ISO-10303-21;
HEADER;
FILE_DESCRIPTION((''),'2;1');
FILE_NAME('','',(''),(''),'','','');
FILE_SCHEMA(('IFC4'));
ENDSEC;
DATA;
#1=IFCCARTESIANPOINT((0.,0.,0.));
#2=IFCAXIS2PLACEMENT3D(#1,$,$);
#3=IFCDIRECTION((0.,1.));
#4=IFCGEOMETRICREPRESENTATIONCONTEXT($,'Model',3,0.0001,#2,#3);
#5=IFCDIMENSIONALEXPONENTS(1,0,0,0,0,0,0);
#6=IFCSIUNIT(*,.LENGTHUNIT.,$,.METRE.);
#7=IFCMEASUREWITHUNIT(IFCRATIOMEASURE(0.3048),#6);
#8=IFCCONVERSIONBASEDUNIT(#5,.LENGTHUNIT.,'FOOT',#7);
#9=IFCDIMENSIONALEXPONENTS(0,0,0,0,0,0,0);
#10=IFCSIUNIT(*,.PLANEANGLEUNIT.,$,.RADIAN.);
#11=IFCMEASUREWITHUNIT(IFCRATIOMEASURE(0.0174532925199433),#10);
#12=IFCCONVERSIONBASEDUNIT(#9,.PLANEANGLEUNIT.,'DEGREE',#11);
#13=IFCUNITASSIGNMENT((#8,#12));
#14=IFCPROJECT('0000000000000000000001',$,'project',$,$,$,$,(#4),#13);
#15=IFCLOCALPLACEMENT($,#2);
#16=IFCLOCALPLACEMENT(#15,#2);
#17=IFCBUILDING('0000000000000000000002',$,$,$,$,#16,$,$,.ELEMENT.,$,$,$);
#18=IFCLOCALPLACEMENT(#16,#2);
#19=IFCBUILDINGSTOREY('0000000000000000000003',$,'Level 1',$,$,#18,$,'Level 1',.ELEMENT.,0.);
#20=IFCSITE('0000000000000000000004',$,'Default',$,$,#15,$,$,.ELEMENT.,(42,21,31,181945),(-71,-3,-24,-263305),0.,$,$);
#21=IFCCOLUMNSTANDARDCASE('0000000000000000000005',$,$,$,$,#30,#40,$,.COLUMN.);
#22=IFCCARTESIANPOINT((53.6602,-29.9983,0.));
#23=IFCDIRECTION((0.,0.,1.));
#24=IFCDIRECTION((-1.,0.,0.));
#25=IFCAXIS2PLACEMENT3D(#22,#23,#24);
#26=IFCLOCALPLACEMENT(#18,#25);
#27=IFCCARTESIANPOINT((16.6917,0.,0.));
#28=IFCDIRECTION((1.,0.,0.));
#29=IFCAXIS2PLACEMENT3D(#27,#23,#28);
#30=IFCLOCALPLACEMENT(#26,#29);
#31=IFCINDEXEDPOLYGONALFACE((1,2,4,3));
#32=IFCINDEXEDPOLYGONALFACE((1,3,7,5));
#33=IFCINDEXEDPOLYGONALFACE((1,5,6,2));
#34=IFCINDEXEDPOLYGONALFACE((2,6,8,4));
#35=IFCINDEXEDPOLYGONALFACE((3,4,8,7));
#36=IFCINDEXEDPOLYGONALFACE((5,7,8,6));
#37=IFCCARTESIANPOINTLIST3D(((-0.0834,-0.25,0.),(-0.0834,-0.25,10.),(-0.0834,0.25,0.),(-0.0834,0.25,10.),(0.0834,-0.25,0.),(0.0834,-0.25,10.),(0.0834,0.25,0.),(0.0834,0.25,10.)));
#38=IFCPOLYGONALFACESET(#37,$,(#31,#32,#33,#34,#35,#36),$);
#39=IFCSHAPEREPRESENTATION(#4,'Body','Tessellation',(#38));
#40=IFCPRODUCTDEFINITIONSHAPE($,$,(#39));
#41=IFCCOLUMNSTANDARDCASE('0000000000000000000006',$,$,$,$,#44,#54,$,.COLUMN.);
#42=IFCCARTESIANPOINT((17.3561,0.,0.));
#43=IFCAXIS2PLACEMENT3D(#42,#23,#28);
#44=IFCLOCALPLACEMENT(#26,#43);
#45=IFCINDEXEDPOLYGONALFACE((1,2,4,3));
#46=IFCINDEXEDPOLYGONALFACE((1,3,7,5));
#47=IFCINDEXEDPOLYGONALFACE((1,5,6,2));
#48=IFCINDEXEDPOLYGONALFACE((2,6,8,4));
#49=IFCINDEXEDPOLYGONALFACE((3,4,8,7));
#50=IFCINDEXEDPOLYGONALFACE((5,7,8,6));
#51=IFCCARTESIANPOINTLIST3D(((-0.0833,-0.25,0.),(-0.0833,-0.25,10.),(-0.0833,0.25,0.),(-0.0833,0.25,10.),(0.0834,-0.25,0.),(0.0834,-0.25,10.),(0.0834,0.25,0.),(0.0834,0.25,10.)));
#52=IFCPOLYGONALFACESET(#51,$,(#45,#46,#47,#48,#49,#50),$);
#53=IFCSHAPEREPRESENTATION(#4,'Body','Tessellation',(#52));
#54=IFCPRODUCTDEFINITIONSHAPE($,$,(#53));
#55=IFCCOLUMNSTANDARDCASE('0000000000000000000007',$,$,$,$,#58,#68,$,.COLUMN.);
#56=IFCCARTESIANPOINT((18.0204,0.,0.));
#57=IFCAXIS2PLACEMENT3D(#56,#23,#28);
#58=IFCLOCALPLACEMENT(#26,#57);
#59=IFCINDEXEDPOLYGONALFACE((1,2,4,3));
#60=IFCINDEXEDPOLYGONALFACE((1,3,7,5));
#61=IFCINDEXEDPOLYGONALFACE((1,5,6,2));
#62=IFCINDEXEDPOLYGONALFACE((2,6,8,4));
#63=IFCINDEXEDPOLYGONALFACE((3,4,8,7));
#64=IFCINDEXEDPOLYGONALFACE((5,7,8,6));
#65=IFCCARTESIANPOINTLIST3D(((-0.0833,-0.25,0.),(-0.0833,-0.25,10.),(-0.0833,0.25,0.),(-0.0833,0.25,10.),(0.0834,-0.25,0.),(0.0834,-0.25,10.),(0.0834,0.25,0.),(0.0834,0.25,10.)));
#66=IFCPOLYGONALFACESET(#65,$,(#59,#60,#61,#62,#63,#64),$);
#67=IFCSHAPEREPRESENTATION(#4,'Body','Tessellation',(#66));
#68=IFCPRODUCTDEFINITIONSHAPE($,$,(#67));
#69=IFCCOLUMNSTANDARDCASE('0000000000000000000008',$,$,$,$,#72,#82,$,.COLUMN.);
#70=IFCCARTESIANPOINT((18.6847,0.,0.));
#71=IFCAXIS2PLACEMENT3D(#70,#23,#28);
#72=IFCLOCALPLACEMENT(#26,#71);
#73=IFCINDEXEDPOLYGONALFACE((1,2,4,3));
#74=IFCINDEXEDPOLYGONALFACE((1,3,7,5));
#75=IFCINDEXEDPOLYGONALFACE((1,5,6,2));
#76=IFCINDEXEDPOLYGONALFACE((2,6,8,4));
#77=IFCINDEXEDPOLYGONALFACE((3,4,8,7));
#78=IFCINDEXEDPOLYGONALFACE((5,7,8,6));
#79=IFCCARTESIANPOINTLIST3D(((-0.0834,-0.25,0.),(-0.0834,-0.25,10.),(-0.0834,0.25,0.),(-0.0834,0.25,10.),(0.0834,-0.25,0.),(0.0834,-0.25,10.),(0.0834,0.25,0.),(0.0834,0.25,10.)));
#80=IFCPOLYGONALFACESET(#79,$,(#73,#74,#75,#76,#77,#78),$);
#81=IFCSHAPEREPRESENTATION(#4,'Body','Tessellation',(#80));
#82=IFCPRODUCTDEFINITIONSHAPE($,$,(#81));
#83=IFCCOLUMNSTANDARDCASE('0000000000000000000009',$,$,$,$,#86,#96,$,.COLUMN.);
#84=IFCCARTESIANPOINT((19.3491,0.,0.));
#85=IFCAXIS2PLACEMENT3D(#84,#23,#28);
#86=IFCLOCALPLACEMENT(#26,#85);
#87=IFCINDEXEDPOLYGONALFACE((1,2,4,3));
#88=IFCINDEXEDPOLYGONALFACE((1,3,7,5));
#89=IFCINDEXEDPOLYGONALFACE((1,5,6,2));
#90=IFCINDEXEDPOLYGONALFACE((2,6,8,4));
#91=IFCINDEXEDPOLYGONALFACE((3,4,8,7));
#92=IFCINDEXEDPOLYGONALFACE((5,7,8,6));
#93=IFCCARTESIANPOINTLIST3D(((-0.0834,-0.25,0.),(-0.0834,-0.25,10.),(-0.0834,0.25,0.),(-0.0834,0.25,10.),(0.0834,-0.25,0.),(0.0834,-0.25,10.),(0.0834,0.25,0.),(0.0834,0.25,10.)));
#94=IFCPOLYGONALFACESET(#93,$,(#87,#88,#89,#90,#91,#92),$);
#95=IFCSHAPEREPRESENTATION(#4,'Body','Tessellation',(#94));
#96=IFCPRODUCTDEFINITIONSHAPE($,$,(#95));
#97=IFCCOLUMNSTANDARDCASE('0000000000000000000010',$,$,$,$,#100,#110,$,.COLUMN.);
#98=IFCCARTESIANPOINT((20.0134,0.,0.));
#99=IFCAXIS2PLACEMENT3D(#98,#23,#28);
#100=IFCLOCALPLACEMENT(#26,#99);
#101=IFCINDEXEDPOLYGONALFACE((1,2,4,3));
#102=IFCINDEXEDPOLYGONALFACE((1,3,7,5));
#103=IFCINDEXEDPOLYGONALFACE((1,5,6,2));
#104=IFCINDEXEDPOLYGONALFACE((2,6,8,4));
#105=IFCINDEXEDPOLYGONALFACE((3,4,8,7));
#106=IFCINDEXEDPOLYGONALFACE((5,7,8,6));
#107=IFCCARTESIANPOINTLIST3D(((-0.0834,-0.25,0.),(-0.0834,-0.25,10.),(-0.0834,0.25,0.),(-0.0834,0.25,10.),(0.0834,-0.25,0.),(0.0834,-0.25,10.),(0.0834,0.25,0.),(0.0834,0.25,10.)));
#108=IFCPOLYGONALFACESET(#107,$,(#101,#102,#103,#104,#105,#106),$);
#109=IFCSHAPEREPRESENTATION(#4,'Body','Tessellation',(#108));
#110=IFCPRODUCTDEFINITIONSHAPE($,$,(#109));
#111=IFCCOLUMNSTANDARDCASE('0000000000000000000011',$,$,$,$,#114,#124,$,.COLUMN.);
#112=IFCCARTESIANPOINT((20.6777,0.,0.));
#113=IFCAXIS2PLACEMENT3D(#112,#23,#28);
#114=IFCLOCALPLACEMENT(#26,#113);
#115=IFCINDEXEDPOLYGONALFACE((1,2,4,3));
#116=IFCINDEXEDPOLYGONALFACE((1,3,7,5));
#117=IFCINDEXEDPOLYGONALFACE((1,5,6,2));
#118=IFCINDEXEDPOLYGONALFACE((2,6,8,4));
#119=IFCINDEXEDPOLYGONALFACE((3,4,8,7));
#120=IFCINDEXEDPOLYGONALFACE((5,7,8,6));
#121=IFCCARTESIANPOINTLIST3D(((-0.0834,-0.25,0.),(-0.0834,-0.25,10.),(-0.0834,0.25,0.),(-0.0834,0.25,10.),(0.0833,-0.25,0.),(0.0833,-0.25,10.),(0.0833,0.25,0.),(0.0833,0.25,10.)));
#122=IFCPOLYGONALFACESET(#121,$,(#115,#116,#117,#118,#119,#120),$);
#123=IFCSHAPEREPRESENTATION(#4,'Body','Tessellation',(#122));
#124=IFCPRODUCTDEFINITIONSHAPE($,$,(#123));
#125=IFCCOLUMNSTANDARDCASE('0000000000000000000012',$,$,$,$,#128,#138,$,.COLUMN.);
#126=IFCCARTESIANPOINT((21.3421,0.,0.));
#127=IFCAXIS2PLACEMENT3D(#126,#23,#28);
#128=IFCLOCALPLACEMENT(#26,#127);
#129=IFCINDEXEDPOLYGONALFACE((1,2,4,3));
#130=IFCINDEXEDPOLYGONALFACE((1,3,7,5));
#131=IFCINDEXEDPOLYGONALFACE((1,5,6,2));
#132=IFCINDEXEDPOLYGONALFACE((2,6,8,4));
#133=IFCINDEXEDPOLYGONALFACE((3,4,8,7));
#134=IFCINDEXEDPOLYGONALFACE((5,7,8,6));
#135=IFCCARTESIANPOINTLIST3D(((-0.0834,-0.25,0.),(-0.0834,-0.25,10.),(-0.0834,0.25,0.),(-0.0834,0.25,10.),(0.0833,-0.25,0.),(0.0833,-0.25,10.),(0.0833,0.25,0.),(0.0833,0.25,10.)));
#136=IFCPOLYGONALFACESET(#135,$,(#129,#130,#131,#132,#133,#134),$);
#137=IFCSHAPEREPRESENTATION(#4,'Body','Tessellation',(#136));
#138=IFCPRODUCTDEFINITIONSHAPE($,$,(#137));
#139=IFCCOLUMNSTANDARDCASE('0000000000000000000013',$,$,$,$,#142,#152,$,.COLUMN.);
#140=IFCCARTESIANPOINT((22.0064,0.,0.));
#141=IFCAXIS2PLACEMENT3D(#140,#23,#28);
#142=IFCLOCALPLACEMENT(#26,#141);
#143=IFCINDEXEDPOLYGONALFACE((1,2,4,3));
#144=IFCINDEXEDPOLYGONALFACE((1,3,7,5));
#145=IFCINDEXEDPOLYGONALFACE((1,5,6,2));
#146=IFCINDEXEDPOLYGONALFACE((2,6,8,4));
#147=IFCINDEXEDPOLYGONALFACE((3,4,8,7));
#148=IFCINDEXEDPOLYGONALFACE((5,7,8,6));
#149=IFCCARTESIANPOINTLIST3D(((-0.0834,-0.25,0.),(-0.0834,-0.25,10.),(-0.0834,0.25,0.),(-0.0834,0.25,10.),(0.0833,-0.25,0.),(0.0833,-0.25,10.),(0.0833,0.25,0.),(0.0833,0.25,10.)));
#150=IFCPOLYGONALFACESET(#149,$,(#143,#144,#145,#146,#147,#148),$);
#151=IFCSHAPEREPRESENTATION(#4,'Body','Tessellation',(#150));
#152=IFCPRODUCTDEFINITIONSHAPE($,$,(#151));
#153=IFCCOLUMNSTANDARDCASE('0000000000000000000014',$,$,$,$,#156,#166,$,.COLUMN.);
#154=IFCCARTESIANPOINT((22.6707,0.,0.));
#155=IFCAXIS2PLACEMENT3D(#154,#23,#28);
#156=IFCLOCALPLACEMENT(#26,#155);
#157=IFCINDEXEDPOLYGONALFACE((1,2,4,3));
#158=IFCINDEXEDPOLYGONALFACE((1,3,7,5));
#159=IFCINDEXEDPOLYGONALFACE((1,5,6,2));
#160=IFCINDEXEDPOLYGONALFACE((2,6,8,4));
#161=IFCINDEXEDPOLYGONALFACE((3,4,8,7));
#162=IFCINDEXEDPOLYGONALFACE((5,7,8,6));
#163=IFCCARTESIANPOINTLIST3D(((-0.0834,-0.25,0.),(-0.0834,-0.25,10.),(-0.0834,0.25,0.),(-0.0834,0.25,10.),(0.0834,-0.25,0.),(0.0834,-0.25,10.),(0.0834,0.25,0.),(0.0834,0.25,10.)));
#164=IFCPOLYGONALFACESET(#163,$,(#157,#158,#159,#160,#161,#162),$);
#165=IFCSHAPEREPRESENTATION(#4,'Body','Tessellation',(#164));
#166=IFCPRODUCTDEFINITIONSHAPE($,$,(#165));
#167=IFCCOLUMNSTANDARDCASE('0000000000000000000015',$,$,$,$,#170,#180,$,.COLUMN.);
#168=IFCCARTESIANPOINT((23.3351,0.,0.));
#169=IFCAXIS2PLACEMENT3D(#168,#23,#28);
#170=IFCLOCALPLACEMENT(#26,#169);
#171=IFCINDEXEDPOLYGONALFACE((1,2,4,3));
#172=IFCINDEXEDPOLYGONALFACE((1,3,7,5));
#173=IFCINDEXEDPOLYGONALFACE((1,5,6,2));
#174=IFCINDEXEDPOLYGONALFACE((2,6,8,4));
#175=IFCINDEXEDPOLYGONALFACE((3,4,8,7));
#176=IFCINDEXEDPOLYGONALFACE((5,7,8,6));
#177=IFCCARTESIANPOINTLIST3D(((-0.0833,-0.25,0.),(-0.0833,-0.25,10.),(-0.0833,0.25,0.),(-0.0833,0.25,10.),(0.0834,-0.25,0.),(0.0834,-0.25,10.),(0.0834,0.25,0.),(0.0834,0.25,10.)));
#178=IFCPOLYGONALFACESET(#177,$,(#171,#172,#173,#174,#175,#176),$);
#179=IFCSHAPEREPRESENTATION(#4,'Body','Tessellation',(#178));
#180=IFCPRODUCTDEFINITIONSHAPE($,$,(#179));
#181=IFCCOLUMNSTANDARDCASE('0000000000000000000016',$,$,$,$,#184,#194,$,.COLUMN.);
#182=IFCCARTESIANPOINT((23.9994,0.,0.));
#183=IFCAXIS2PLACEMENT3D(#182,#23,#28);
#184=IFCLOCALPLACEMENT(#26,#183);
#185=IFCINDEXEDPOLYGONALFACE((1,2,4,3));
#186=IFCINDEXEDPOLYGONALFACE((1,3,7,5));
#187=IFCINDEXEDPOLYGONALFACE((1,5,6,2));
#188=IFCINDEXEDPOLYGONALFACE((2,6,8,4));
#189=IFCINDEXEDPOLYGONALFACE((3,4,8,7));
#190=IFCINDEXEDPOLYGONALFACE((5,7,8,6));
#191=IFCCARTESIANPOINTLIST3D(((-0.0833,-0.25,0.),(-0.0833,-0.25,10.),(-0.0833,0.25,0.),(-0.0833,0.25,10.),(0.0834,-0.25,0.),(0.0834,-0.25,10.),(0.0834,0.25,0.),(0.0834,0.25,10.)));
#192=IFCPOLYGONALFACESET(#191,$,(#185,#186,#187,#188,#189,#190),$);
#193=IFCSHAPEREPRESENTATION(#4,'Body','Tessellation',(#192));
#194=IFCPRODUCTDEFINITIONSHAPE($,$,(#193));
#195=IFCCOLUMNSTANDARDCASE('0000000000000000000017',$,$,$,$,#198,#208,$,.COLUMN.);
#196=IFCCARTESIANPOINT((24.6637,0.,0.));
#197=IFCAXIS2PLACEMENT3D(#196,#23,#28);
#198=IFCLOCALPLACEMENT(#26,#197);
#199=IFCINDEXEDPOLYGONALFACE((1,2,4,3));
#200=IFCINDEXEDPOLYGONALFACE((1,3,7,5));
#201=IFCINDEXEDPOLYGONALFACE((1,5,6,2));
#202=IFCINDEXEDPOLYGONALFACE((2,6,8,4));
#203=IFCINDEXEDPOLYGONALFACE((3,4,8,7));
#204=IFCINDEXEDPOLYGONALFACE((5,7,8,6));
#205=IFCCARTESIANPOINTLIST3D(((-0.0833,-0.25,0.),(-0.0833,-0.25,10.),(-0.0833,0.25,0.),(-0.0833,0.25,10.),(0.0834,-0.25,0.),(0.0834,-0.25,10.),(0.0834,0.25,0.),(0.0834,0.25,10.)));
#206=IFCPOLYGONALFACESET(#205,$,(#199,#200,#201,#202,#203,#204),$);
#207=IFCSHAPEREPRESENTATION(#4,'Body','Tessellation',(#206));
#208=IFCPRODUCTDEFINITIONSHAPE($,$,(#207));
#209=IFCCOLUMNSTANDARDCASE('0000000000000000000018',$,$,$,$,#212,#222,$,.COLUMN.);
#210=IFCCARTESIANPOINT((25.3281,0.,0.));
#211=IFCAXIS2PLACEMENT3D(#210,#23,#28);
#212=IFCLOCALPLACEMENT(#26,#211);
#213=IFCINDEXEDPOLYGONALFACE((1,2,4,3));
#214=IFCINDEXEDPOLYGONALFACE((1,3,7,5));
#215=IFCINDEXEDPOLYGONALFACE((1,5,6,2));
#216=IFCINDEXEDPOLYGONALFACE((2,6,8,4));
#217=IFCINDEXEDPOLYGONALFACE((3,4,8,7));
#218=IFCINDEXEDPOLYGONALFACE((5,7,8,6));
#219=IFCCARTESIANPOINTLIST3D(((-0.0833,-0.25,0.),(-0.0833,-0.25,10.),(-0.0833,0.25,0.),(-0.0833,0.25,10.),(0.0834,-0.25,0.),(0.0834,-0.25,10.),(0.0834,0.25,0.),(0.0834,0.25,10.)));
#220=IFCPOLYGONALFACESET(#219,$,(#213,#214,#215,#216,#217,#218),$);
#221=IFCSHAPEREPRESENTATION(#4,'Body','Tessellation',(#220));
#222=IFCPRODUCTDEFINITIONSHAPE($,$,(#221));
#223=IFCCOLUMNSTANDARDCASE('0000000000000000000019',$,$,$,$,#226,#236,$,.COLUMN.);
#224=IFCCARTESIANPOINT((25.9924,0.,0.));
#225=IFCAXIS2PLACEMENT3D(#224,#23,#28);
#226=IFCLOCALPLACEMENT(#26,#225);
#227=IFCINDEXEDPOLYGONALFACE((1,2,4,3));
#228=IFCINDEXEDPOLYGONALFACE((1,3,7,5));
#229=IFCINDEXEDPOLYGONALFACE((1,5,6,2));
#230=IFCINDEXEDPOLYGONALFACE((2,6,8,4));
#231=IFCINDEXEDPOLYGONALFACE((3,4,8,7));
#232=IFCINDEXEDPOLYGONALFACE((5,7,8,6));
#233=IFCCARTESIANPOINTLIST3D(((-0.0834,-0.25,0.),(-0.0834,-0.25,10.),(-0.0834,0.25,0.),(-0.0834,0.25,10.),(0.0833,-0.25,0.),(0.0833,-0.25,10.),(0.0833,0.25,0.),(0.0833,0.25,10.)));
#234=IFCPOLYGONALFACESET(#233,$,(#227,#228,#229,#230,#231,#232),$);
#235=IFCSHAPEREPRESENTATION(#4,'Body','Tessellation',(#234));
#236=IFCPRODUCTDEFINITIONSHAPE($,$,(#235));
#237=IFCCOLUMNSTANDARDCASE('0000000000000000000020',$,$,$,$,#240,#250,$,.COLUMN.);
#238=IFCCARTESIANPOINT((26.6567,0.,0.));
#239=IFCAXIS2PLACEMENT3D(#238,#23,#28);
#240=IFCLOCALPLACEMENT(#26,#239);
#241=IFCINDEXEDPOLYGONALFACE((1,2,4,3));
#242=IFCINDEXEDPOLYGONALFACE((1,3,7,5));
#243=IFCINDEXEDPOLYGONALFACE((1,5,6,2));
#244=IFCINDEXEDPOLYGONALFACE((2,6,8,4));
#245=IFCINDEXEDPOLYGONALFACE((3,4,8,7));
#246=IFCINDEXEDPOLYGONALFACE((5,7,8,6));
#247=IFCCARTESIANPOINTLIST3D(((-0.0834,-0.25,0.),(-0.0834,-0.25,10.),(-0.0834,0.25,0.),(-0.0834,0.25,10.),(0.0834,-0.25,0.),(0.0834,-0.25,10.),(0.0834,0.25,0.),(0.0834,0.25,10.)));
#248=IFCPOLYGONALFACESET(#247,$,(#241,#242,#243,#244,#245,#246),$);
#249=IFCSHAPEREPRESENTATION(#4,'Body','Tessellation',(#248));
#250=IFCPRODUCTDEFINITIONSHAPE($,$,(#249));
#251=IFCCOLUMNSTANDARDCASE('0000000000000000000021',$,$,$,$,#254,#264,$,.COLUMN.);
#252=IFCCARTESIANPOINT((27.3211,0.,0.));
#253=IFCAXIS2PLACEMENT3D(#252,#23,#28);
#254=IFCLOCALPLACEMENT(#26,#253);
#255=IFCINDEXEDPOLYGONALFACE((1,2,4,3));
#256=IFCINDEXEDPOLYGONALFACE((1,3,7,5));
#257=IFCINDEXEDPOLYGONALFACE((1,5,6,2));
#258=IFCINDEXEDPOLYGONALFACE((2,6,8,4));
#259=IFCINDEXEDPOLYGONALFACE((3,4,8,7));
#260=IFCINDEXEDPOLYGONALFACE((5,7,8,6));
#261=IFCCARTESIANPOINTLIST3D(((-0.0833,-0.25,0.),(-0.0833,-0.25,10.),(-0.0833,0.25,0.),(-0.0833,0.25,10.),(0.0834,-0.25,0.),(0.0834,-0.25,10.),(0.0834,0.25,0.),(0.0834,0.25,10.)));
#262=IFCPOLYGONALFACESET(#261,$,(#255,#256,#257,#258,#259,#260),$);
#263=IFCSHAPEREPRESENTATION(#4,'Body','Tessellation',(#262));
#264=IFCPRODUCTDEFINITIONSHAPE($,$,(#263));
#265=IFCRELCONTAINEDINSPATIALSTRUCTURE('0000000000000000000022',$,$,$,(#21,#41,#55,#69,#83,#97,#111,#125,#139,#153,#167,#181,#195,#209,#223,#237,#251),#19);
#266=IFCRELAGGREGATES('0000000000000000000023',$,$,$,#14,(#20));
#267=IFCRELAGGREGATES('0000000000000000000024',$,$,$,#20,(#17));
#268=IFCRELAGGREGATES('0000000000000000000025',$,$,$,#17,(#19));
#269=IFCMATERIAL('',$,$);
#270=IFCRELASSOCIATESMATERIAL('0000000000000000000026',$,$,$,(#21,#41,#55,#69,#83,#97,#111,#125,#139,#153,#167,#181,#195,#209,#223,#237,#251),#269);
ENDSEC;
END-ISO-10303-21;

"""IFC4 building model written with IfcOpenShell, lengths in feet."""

from ifc_helpers import new_model, entity, si_unit, converted_unit, direction, frame, origin, place, context, project, spatial, rectangle, extrude, material, element, save


model = new_model("IFC4")

# Units and contexts
model_context = context("Model", 3, precision=0.0001, world=origin(), true_north=direction((0.0, 1.0)))
ifc_project = project(units=[converted_unit("LENGTHUNIT", "FOOT", entity("IfcRatioMeasure", 0.3048), si_unit("LENGTHUNIT", "METRE"), dimensions=[1, 0, 0, 0, 0, 0, 0]), converted_unit("PLANEANGLEUNIT", "DEGREE", entity("IfcRatioMeasure", 0.0174532925199433), si_unit("PLANEANGLEUNIT", "RADIAN"), dimensions=[0, 0, 0, 0, 0, 0, 0])], contexts=[model_context])

# Site, building, storey
site_placement = place(None, origin())
site = spatial("IfcSite", under=ifc_project, at=site_placement, Name="Default", CompositionType="ELEMENT", RefLatitude=(42, 21, 31, 181945), RefLongitude=(-71, -3, -24, -263305), RefElevation=0.0)
building_placement = place(site_placement, origin())
building = spatial("IfcBuilding", under=site, at=building_placement, CompositionType="ELEMENT")
storey_placement = place(building_placement, origin())
storey = spatial("IfcBuildingStorey", under=building, at=storey_placement, Name="Level 1", LongName="Level 1", CompositionType="ELEMENT", Elevation=0.0)

# Columns
ifc_material = material(Name="")
placement = place(storey_placement, frame((53.6602, -29.9983, 0.0), z_axis=(0.0, 0.0, 1.0), x_axis=(-1.0, 0.0, 0.0)))
for number, where, z_axis, x_axis in (
    (1, (16.6917, 0.0, 0.0), (0.0, 0.0, 1.0), (1.0, 0.0, 0.0)),
    (2, (17.3561, 0.0, 0.0), (0.0, 0.0, 1.0), (1.0, 0.0, 0.0)),
    (3, (18.0204, 0.0, 0.0), (0.0, 0.0, 1.0), (1.0, 0.0, 0.0)),
    (4, (18.6847, 0.0, 0.0), (0.0, 0.0, 1.0), (1.0, 0.0, 0.0)),
    (5, (19.3491, 0.0, 0.0), (0.0, 0.0, 1.0), (1.0, 0.0, 0.0)),
    (6, (20.0134, 0.0, 0.0), (0.0, 0.0, 1.0), (1.0, 0.0, 0.0)),
    (7, (20.6777, 0.0, 0.0), (0.0, 0.0, 1.0), (1.0, 0.0, 0.0)),
    (8, (21.3421, 0.0, 0.0), (0.0, 0.0, 1.0), (1.0, 0.0, 0.0)),
    (9, (22.0064, 0.0, 0.0), (0.0, 0.0, 1.0), (1.0, 0.0, 0.0)),
    (10, (22.6707, 0.0, 0.0), (0.0, 0.0, 1.0), (1.0, 0.0, 0.0)),
    (11, (23.3351, 0.0, 0.0), (0.0, 0.0, 1.0), (1.0, 0.0, 0.0)),
    (12, (23.9994, 0.0, 0.0), (0.0, 0.0, 1.0), (1.0, 0.0, 0.0)),
    (13, (24.6637, 0.0, 0.0), (0.0, 0.0, 1.0), (1.0, 0.0, 0.0)),
    (14, (25.3281, 0.0, 0.0), (0.0, 0.0, 1.0), (1.0, 0.0, 0.0)),
    (15, (25.9924, 0.0, 0.0), (0.0, 0.0, 1.0), (1.0, 0.0, 0.0)),
    (16, (26.6567, 0.0, 0.0), (0.0, 0.0, 1.0), (1.0, 0.0, 0.0)),
    (17, (27.3211, 0.0, 0.0), (0.0, 0.0, 1.0), (1.0, 0.0, 0.0)),
):
    element("IfcColumnStandardCase", number, at=place(placement, frame(where, z_axis=z_axis, x_axis=x_axis)), inside=storey, material=ifc_material, PredefinedType="COLUMN", context=model_context, shape_type="SweptSolid", body=[
        extrude(rectangle(XDim=0.1667, YDim=0.5), origin(), (0.0, 0.0, 1.0), 10.0),
    ])

save(model, "model.ifc")
